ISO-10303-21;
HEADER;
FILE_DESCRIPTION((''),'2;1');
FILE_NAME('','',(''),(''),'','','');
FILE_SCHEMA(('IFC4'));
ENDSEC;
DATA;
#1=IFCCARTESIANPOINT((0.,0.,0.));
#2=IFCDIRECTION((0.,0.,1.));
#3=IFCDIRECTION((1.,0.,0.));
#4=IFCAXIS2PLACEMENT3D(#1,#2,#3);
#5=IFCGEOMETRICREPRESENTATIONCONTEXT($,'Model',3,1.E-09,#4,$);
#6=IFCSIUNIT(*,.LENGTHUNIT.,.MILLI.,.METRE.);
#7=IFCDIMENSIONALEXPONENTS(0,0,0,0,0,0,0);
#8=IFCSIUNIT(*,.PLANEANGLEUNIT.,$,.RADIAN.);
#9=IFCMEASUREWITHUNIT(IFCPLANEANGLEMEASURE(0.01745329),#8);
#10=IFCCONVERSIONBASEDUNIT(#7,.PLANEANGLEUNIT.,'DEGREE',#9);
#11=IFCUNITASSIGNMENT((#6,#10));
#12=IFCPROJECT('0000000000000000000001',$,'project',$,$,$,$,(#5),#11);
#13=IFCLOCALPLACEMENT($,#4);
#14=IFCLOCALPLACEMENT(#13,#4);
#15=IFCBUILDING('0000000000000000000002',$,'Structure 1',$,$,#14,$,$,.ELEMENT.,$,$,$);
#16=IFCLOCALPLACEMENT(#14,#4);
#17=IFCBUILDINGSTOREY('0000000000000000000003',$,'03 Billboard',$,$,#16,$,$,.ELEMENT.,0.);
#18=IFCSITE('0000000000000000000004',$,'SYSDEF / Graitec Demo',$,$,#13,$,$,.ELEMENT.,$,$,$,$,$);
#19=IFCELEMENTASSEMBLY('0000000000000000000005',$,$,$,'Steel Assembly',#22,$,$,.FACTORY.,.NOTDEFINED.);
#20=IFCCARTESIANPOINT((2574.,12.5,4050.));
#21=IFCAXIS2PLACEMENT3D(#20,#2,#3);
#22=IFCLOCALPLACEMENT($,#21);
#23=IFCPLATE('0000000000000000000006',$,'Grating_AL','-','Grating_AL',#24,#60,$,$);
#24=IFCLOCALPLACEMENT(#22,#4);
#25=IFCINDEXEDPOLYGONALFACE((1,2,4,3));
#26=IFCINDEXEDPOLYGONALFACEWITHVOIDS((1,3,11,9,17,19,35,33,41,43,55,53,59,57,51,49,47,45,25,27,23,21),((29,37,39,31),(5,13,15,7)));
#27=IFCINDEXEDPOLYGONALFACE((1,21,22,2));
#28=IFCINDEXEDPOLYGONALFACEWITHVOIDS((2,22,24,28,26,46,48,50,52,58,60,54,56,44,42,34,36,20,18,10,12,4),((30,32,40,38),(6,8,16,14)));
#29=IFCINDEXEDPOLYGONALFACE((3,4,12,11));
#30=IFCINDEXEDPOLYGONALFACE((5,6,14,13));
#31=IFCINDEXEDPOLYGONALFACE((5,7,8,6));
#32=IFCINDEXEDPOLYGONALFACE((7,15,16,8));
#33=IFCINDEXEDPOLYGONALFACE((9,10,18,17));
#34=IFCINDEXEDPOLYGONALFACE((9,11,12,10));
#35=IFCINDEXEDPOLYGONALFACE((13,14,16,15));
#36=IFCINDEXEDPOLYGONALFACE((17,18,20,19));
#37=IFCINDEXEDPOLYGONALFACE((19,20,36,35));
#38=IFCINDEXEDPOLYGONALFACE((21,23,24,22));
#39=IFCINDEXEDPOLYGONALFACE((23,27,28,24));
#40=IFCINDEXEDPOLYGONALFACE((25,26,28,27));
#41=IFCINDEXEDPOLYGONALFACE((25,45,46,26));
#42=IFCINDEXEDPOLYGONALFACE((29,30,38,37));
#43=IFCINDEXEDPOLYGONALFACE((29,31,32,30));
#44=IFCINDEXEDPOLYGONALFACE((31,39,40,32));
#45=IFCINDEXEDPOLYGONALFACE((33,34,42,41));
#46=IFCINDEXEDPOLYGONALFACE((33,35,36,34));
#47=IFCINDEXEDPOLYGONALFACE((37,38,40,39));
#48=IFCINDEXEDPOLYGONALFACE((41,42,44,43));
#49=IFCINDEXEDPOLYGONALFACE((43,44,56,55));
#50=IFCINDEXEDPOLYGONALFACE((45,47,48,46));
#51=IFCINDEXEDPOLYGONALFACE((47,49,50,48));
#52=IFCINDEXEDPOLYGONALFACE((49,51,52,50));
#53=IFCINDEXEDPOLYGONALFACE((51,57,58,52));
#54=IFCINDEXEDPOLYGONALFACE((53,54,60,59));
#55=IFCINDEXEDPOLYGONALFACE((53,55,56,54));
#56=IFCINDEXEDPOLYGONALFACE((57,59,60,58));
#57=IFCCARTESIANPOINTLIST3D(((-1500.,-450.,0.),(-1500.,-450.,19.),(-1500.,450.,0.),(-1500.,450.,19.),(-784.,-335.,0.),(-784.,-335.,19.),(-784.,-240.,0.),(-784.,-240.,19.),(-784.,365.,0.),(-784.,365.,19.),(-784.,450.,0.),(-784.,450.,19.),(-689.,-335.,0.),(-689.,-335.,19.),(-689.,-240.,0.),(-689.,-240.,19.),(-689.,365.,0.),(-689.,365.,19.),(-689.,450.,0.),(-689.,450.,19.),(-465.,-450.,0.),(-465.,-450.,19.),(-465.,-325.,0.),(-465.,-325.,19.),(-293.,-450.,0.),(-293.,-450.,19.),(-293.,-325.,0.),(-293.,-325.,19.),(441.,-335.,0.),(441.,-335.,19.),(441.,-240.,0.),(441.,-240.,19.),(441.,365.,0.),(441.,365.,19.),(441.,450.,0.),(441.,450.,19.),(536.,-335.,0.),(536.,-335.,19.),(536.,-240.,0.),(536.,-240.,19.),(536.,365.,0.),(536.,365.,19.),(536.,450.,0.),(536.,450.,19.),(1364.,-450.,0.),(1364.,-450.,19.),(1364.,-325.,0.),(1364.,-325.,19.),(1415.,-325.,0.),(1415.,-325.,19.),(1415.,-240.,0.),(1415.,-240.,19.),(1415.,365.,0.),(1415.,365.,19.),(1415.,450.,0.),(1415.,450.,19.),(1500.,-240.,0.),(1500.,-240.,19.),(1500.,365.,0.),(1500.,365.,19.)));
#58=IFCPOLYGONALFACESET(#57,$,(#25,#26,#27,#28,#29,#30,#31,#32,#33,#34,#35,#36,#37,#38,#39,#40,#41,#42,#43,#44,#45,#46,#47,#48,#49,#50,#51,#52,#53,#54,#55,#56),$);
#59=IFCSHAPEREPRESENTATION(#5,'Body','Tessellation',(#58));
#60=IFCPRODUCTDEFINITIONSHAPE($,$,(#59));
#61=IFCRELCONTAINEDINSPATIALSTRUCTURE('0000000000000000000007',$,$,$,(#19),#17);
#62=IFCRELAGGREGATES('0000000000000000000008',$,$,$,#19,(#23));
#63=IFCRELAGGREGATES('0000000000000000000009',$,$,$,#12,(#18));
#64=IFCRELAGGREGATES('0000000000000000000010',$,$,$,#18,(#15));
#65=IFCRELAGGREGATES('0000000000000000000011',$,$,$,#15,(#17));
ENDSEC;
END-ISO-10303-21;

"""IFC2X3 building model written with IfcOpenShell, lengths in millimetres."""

from ifc_helpers import new_model, entity, si_unit, converted_unit, frame, origin, origin_with_axes, place, context, project, spatial, polyline, outline, extrude, element, aggregate, save


model = new_model("IFC2X3")

# Units and contexts
model_context = context("Model", 3, precision=1e-09, world=origin_with_axes())
ifc_project = project(units=[si_unit("LENGTHUNIT", "METRE", prefix="MILLI"), converted_unit("PLANEANGLEUNIT", "DEGREE", entity("IfcPlaneAngleMeasure", 0.01745329), si_unit("PLANEANGLEUNIT", "RADIAN"), dimensions=[0, 0, 0, 0, 0, 0, 0])], contexts=[model_context])

# Site, building, storey
site_placement = place(None, origin_with_axes())
site = spatial("IfcSite", under=ifc_project, at=site_placement, Name="SYSDEF / Graitec Demo", CompositionType="ELEMENT")
building_placement = place(site_placement, origin_with_axes())
building = spatial("IfcBuilding", under=site, at=building_placement, Name="Structure 1", CompositionType="ELEMENT")
storey_placement = place(building_placement, origin_with_axes())
storey = spatial("IfcBuildingStorey", under=building, at=storey_placement, Name="03 Billboard", CompositionType="ELEMENT", Elevation=0.0)

# Element assembly, plate, openings
assembly_1_placement = place(None, frame((2574.0, 12.5, 4050.0), z_axis=(0.0, 0.0, 1.0), x_axis=(1.0, 0.0, 0.0)))
assembly_1 = element("IfcElementAssembly", 1, at=assembly_1_placement, inside=storey, ObjectType="Steel Assembly", AssemblyPlace="FACTORY", PredefinedType="NOTDEFINED")
plate_1_placement = place(assembly_1_placement, origin_with_axes())
plate_1 = element("IfcPlate", 2, at=plate_1_placement, Name="Grating_AL", Description="-", ObjectType="Grating_AL", context=model_context, shape_type="SweptSolid", body=[
    extrude(outline(polyline([(-1500.0, -450.0), (1500.0, -450.0), (1500.0, 450.0), (-1500.0, 450.0), (-1500.0, -450.0)])), origin_with_axes(), (0.0, 0.0, 1.0), 19.0),
])
opening_1_placement = place(plate_1_placement, frame((0.0, 0.0, -0.1), z_axis=(0.0, 0.0, 1.0), x_axis=(1.0, 0.0, 0.0)))
element("IfcOpeningElement", 3, at=opening_1_placement, cuts=plate_1, ObjectType="Opening", context=model_context, shape_type="SweptSolid", body=[
    extrude(outline(polyline([(-784.0, 365.0), (-689.0, 365.0), (-689.0, 460.0), (-784.0, 460.0), (-784.0, 365.0)])), origin(), (0.0, 0.0, 1.0), 19.2),
])
opening_2_placement = place(plate_1_placement, frame((0.0, 0.0, -0.1), z_axis=(0.0, 0.0, 1.0), x_axis=(1.0, 0.0, 0.0)))
element("IfcOpeningElement", 4, at=opening_2_placement, cuts=plate_1, ObjectType="Opening", context=model_context, shape_type="SweptSolid", body=[
    extrude(outline(polyline([(-784.0, -335.0), (-689.0, -335.0), (-689.0, -240.0), (-784.0, -240.0), (-784.0, -335.0)])), origin(), (0.0, 0.0, 1.0), 19.2),
])
opening_3_placement = place(plate_1_placement, frame((0.0, 0.0, -0.1), z_axis=(0.0, 0.0, 1.0), x_axis=(1.0, 0.0, 0.0)))
element("IfcOpeningElement", 5, at=opening_3_placement, cuts=plate_1, ObjectType="Opening", context=model_context, shape_type="SweptSolid", body=[
    extrude(outline(polyline([(441.0, 365.0), (536.0, 365.0), (536.0, 460.0), (441.0, 460.0), (441.0, 365.0)])), origin(), (0.0, 0.0, 1.0), 19.2),
])
opening_4_placement = place(plate_1_placement, frame((0.0, 0.0, -0.1), z_axis=(0.0, 0.0, 1.0), x_axis=(1.0, 0.0, 0.0)))
element("IfcOpeningElement", 6, at=opening_4_placement, cuts=plate_1, ObjectType="Opening", context=model_context, shape_type="SweptSolid", body=[
    extrude(outline(polyline([(441.0, -335.0), (536.0, -335.0), (536.0, -240.0), (441.0, -240.0), (441.0, -335.0)])), origin(), (0.0, 0.0, 1.0), 19.2),
])
opening_5_placement = place(plate_1_placement, frame((0.0, 0.0, -0.1), z_axis=(0.0, 0.0, 1.0), x_axis=(1.0, 0.0, 0.0)))
element("IfcOpeningElement", 7, at=opening_5_placement, cuts=plate_1, ObjectType="Opening", context=model_context, shape_type="SweptSolid", body=[
    extrude(outline(polyline([(1415.0, 365.0), (1510.0, 365.0), (1510.0, 460.0), (1415.0, 460.0), (1415.0, 365.0)])), origin(), (0.0, 0.0, 1.0), 19.2),
])
opening_6_placement = place(plate_1_placement, frame((0.0, 0.0, -0.1), z_axis=(0.0, 0.0, 1.0), x_axis=(1.0, 0.0, 0.0)))
element("IfcOpeningElement", 8, at=opening_6_placement, cuts=plate_1, ObjectType="Opening", context=model_context, shape_type="SweptSolid", body=[
    extrude(outline(polyline([(1415.0, -335.0), (1510.0, -335.0), (1510.0, -240.0), (1415.0, -240.0), (1415.0, -335.0)])), origin(), (0.0, 0.0, 1.0), 19.2),
])
opening_7_placement = place(plate_1_placement, frame((0.0, 0.0, -0.1), z_axis=(0.0, 0.0, 1.0), x_axis=(1.0, 0.0, 0.0)))
element("IfcOpeningElement", 9, at=opening_7_placement, cuts=plate_1, ObjectType="Opening", context=model_context, shape_type="SweptSolid", body=[
    extrude(outline(polyline([(1364.0, -485.0), (1510.0, -485.0), (1510.0, -325.0), (1364.0, -325.0), (1364.0, -485.0)])), origin(), (0.0, 0.0, 1.0), 19.2),
])
opening_8_placement = place(plate_1_placement, frame((0.0, 0.0, -0.1), z_axis=(0.0, 0.0, 1.0), x_axis=(1.0, 0.0, 0.0)))
element("IfcOpeningElement", 10, at=opening_8_placement, cuts=plate_1, ObjectType="Opening", context=model_context, shape_type="SweptSolid", body=[
    extrude(outline(polyline([(-465.0, -485.0), (-293.0, -485.0), (-293.0, -325.0), (-465.0, -325.0), (-465.0, -485.0)])), origin(), (0.0, 0.0, 1.0), 19.2),
])
aggregate(assembly_1, [plate_1])

save(model, "model.ifc")
